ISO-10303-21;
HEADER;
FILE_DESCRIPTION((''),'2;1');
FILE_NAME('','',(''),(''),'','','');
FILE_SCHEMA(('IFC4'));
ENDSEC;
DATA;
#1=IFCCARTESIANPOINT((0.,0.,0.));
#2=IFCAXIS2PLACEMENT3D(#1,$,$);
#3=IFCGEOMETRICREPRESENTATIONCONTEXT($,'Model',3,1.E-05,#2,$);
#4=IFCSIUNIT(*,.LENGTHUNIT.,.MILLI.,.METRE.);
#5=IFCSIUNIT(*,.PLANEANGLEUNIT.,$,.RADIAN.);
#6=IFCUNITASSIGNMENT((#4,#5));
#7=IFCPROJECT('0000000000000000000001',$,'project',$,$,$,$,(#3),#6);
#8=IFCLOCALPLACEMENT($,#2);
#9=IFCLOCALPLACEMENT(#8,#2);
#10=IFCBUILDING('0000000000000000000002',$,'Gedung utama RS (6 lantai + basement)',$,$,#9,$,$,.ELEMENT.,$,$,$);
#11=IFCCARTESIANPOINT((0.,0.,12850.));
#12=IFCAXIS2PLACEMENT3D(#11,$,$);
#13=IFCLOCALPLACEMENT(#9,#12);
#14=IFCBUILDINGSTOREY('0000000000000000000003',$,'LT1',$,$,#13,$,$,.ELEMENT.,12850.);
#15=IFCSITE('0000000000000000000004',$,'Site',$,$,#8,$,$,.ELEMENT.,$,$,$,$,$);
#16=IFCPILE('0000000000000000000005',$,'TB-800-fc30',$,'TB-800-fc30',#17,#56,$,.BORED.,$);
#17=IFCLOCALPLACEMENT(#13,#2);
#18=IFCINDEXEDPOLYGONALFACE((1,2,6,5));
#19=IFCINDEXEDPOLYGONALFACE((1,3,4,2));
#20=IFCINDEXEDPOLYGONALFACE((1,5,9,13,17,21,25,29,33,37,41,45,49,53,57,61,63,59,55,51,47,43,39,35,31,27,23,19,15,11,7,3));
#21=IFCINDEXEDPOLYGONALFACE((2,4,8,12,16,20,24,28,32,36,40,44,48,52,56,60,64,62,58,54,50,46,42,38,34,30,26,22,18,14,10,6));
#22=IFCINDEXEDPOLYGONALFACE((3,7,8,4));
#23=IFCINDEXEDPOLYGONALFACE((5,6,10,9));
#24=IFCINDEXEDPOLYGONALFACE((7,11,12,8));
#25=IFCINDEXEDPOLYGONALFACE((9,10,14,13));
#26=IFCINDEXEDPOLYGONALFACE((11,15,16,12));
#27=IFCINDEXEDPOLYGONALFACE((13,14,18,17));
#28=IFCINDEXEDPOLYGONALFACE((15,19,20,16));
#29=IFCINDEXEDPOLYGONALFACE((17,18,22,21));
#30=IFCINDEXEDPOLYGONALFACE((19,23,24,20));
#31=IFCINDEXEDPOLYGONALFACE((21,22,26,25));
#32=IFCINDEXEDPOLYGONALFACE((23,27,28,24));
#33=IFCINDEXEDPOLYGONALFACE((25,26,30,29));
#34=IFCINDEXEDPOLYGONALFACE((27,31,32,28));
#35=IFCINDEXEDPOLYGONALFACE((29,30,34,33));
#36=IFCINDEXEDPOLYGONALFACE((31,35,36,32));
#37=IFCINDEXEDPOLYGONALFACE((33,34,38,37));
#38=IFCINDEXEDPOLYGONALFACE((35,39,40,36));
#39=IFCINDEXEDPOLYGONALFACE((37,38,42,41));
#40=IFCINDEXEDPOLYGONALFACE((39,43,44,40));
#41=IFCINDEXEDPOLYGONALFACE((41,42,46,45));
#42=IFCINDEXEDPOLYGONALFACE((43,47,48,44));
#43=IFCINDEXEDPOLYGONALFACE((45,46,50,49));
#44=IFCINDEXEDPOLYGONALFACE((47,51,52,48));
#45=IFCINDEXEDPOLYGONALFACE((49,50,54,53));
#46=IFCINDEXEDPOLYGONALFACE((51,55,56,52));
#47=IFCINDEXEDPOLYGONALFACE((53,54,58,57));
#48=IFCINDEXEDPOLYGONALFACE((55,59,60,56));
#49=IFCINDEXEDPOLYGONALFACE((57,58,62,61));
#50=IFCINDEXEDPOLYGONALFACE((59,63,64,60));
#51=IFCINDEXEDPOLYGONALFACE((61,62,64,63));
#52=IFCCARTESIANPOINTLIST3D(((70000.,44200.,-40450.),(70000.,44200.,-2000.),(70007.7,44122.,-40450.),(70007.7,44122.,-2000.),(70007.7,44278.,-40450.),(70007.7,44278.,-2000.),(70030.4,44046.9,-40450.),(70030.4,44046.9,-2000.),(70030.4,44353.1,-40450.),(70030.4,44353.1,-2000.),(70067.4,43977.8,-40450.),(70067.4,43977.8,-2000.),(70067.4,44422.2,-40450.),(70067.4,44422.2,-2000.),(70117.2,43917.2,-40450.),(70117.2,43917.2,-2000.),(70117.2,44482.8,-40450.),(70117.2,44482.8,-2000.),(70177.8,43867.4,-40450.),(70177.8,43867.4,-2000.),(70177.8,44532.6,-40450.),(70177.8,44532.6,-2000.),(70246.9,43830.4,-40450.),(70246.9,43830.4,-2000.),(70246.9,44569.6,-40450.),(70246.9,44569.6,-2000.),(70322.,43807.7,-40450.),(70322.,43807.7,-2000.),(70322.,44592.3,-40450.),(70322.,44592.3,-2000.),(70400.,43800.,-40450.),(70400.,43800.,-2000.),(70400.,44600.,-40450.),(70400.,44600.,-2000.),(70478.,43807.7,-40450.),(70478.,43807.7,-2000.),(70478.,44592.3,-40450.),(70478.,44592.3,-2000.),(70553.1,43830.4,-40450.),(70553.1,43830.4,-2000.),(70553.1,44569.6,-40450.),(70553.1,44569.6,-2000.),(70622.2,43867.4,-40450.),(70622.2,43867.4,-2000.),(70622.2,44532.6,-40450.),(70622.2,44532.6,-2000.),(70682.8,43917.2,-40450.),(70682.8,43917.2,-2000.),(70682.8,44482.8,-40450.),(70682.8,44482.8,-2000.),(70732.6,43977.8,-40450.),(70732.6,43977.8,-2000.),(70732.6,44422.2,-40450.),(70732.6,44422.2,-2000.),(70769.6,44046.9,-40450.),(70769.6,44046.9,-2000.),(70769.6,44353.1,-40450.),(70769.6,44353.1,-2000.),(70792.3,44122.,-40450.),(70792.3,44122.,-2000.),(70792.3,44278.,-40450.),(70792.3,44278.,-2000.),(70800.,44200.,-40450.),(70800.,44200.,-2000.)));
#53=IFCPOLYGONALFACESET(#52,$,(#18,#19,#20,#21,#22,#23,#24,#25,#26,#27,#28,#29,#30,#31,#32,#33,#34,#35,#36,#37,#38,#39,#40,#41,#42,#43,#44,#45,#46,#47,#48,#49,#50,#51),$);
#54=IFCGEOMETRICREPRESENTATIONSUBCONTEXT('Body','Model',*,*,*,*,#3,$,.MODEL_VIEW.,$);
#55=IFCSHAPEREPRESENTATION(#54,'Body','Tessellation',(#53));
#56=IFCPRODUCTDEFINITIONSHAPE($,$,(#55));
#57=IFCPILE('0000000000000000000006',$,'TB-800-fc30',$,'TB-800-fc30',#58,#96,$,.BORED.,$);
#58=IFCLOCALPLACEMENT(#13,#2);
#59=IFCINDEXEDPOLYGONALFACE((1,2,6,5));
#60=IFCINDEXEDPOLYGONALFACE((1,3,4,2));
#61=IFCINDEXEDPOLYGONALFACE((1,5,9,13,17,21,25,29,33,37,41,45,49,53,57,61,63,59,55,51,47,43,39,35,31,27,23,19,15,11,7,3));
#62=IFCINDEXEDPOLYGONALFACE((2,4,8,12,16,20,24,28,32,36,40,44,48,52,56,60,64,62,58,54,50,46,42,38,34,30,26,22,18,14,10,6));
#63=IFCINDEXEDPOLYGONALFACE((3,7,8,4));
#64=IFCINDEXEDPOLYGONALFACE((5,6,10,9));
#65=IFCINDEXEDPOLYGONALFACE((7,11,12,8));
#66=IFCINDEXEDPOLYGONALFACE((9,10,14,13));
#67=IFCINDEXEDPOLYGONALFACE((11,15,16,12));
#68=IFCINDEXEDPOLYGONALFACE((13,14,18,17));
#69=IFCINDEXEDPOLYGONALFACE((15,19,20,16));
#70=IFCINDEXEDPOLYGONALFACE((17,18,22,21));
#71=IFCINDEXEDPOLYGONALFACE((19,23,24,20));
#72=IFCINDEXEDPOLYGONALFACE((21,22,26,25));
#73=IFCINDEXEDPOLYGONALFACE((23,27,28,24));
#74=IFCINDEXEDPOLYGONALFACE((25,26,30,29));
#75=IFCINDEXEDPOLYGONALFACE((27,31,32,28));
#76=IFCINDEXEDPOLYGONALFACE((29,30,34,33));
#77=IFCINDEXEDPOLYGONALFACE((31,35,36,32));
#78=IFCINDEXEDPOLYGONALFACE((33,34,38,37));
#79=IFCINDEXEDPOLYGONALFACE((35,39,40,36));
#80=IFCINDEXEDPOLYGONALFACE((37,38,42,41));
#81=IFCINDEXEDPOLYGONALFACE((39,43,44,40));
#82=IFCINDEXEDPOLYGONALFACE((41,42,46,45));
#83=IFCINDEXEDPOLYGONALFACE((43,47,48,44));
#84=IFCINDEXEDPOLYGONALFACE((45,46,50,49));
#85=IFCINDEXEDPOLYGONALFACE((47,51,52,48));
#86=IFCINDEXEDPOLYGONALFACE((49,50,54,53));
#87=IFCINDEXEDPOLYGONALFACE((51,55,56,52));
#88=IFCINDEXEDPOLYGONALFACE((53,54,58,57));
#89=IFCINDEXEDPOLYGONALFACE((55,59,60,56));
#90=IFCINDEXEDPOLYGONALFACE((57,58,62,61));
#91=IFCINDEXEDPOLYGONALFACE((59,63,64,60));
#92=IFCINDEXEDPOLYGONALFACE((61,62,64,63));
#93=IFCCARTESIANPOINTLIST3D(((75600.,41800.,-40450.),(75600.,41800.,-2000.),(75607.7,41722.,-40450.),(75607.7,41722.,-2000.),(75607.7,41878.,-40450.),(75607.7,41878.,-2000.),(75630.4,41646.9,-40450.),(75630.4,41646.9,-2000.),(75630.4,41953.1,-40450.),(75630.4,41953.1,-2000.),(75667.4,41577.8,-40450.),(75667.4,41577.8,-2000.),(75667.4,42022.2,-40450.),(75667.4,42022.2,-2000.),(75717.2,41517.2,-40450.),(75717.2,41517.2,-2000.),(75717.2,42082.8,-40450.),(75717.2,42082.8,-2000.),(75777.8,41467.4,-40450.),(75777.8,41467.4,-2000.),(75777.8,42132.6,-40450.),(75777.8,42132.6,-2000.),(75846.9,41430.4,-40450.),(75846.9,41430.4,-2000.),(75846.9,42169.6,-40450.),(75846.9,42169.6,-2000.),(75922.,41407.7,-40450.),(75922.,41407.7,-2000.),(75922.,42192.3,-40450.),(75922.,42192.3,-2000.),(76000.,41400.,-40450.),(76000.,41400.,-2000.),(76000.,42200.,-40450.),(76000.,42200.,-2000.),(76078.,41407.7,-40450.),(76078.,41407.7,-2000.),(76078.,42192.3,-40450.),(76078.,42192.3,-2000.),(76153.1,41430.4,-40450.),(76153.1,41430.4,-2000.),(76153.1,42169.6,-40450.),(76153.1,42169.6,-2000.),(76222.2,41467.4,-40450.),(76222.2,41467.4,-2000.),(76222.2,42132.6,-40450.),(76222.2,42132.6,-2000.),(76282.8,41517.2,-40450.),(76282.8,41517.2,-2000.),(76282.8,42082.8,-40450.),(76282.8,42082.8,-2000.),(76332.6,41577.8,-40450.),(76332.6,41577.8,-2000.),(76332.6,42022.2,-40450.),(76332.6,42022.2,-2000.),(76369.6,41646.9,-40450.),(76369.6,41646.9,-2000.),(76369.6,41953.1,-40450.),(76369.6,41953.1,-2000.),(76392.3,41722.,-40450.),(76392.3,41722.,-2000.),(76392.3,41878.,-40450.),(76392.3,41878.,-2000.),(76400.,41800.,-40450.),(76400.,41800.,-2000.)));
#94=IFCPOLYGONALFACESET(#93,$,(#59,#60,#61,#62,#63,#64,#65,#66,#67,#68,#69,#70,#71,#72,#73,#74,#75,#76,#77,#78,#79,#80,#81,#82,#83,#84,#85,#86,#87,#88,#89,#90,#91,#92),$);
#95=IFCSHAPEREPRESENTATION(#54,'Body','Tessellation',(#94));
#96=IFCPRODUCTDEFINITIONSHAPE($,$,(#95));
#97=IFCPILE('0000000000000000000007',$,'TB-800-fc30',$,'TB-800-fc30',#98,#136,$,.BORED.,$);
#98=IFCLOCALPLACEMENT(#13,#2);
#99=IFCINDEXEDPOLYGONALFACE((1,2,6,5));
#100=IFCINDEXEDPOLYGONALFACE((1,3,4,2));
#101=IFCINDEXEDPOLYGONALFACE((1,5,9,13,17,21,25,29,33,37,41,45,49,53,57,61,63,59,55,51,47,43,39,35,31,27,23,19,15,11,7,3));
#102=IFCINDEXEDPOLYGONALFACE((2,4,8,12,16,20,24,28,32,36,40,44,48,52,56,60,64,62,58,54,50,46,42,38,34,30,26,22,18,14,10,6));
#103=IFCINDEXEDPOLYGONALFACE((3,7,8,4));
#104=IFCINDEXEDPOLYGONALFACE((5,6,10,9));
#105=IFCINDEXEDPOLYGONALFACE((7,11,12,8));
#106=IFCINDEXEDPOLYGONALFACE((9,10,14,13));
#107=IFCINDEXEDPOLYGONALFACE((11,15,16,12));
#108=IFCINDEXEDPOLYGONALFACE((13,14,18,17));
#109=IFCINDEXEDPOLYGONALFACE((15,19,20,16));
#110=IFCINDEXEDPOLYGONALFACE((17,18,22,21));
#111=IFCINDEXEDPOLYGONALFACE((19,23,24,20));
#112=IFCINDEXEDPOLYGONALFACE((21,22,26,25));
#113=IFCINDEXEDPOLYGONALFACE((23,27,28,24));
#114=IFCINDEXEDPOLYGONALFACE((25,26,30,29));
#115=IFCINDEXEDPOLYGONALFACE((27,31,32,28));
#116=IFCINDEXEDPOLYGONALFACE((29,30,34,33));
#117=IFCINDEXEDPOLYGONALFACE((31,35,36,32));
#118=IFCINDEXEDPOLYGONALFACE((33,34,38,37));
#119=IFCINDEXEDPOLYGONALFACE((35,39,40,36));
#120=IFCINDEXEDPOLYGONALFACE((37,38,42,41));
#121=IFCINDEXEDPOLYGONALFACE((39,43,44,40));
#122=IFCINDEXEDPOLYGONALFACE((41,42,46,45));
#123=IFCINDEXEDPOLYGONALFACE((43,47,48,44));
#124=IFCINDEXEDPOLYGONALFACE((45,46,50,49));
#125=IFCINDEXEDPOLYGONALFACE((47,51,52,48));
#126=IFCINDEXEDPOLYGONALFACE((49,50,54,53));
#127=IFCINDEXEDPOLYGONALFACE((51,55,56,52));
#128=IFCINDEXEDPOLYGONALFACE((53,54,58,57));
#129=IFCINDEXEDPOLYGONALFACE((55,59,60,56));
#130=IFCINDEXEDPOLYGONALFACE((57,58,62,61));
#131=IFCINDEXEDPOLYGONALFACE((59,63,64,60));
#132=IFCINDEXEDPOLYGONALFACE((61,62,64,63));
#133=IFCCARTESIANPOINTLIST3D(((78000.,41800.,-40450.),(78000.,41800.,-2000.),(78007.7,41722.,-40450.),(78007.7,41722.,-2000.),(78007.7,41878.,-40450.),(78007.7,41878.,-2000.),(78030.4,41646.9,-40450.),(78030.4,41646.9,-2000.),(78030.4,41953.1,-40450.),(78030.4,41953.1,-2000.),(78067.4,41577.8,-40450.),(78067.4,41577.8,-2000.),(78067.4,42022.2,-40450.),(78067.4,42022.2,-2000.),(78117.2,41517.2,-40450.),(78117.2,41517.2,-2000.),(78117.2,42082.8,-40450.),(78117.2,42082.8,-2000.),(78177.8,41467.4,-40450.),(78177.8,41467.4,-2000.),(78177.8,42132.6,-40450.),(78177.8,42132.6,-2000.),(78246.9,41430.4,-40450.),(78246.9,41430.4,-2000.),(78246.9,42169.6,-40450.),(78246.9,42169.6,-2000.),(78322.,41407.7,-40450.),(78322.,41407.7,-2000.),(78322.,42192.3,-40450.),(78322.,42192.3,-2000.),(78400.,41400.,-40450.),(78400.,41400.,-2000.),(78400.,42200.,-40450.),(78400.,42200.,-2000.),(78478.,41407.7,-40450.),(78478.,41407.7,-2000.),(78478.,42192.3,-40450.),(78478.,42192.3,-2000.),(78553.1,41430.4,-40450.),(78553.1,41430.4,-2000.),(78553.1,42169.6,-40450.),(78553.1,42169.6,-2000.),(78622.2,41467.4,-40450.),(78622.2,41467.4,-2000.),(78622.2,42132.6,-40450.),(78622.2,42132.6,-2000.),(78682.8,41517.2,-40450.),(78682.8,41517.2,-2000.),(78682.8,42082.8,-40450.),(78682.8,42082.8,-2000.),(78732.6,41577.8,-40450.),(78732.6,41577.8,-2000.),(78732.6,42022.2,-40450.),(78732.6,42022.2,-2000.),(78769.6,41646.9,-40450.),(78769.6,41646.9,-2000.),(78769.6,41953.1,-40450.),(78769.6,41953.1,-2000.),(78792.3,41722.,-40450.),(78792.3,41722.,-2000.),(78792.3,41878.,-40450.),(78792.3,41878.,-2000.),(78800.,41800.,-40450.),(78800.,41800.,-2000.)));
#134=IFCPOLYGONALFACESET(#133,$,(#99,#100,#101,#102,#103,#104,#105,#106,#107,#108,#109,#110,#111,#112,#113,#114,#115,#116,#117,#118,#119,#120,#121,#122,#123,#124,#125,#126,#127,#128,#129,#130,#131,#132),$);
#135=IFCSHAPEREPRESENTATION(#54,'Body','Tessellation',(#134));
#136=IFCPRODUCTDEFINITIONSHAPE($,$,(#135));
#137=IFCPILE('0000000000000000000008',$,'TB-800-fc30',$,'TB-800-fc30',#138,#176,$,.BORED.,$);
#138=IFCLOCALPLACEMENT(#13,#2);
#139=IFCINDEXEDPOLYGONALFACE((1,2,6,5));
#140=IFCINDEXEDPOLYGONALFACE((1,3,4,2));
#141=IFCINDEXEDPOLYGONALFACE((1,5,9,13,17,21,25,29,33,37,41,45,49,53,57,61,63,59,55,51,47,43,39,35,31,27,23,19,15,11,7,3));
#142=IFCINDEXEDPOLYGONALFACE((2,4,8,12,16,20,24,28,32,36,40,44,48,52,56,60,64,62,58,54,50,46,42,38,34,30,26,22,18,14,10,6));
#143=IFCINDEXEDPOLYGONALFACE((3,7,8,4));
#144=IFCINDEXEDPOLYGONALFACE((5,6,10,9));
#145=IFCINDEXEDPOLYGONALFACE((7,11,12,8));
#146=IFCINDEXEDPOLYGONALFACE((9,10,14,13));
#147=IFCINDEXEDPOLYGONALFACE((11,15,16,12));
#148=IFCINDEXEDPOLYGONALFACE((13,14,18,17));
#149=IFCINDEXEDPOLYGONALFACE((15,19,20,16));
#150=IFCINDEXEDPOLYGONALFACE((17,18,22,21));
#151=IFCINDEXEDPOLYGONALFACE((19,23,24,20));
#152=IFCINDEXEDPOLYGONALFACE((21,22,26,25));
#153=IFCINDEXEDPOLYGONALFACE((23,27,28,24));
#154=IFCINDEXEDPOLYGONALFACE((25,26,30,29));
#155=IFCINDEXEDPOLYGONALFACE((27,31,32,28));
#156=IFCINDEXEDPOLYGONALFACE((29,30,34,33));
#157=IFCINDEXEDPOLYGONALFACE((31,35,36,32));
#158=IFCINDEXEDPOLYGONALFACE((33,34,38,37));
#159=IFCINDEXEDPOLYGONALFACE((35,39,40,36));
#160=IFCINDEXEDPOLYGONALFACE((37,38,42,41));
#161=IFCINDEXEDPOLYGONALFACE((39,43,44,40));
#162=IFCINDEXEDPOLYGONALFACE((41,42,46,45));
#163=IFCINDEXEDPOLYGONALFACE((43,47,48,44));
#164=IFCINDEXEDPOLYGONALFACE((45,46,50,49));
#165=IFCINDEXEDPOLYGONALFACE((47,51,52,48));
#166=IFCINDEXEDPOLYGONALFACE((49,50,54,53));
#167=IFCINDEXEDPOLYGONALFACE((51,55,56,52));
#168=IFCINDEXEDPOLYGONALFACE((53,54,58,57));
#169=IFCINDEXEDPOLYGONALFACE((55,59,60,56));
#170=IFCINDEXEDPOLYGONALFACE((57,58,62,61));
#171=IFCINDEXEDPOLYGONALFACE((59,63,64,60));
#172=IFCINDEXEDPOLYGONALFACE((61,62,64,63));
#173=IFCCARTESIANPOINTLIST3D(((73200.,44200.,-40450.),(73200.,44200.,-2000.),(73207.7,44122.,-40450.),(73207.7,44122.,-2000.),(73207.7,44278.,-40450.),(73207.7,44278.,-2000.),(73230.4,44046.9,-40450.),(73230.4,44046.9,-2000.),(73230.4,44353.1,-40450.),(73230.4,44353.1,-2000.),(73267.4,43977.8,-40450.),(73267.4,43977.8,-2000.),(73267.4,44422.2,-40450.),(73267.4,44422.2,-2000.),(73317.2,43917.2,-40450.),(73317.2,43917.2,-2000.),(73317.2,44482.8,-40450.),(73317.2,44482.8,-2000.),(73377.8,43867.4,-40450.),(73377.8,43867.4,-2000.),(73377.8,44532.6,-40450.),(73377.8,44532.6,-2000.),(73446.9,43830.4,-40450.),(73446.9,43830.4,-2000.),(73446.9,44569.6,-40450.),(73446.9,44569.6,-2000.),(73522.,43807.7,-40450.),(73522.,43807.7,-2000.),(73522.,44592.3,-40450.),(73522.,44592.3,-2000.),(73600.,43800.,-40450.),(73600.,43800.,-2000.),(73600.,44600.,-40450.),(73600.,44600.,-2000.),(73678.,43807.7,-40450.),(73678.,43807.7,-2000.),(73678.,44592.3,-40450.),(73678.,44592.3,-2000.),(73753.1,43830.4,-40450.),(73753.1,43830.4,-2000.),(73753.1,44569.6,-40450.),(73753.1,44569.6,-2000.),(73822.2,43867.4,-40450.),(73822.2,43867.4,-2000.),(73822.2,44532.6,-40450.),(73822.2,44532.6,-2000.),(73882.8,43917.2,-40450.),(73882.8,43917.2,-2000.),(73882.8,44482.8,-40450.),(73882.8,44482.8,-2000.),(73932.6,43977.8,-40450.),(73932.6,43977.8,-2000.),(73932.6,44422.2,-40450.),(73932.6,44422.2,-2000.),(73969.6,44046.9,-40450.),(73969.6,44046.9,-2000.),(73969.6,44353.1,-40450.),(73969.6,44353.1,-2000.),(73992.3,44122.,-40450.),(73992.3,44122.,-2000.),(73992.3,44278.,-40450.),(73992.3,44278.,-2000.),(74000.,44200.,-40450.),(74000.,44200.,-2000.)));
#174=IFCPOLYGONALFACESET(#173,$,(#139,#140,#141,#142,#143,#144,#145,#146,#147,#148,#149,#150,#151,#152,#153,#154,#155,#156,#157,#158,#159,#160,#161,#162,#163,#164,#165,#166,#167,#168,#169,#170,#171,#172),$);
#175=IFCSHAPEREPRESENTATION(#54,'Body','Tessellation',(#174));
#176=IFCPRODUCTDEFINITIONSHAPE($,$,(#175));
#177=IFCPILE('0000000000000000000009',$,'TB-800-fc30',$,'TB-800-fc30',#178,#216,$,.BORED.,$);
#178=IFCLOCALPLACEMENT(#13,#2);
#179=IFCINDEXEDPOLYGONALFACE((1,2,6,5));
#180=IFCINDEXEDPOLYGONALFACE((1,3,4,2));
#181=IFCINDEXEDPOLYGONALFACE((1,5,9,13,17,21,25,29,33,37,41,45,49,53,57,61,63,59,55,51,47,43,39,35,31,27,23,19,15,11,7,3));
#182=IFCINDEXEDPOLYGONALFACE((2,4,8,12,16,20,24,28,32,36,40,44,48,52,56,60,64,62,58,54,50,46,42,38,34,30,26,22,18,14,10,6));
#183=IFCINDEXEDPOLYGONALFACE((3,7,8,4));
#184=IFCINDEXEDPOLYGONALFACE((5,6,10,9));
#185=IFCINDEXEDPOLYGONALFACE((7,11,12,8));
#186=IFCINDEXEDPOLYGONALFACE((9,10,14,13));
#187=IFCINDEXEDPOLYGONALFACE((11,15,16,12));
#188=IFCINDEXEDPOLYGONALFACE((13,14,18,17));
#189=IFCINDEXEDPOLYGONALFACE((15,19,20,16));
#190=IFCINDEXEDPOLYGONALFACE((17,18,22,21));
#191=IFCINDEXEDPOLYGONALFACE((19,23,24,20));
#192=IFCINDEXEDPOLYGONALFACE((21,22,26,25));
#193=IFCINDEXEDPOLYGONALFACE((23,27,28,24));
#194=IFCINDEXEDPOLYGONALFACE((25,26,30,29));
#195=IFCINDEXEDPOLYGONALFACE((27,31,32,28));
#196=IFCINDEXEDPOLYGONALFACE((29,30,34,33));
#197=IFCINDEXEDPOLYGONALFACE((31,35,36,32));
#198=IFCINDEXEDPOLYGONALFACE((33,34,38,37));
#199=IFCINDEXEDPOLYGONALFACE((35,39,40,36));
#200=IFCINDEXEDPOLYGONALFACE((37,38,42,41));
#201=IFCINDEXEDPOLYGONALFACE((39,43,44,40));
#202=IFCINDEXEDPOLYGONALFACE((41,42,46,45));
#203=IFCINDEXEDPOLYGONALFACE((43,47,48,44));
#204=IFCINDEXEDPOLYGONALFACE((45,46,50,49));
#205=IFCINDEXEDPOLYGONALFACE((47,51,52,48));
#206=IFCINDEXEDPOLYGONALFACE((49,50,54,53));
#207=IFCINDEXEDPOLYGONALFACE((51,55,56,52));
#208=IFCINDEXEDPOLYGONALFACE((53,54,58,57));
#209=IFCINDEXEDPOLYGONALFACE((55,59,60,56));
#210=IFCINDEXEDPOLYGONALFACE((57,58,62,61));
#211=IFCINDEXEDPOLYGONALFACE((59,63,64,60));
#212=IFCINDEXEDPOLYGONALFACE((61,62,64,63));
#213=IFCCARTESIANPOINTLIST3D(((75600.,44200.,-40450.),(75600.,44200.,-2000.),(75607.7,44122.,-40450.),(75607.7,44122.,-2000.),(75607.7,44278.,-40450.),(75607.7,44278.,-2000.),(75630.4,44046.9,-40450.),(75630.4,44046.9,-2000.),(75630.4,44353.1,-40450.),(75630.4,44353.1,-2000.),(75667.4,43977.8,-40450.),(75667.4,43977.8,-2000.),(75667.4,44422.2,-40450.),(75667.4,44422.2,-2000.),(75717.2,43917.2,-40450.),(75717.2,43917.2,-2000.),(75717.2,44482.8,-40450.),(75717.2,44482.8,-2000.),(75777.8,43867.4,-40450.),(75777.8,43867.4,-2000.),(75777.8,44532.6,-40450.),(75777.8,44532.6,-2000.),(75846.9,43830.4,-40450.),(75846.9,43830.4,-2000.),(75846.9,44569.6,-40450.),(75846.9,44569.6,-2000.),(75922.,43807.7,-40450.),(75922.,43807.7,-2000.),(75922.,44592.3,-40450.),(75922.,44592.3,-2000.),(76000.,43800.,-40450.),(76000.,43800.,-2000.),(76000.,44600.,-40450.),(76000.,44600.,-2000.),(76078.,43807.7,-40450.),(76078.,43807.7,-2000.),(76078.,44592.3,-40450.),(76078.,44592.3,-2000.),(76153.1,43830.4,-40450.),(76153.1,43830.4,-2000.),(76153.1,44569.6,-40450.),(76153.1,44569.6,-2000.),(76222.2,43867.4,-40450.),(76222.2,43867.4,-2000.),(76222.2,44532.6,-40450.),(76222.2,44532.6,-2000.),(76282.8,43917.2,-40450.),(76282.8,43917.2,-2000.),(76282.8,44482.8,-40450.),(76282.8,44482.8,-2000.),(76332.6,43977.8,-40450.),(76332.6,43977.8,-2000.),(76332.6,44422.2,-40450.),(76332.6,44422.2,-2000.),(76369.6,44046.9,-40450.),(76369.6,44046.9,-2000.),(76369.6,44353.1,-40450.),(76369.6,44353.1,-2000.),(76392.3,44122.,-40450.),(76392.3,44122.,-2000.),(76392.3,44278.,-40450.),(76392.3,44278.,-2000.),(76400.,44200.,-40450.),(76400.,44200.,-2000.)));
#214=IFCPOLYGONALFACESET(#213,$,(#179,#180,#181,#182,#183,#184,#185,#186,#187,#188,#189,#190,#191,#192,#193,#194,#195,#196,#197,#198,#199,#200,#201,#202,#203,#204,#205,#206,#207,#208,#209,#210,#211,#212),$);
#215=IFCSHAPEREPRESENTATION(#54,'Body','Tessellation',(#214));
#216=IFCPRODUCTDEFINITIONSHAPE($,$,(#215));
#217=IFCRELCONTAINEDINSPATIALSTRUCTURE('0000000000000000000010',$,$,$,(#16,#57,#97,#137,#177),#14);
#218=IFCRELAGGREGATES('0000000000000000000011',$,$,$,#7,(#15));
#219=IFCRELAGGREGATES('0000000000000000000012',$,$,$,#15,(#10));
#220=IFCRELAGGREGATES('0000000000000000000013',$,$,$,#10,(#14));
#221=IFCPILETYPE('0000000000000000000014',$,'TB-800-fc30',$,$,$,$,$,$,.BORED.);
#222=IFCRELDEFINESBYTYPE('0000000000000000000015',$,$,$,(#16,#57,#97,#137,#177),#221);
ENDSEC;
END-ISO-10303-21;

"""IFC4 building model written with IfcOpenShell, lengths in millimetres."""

from ifc_helpers import new_model, si_unit, frame, origin, origin_2d, place, context, subcontext, project, spatial, circle, extrude, material_profile, profile_set, profile_usage, type_object, element, save


model = new_model("IFC4")

# Units and contexts
model_context = context("Model", 3, precision=1e-05, world=origin())
body_context = subcontext(model_context, "Body", "Model", "MODEL_VIEW")
ifc_project = project(units=[si_unit("LENGTHUNIT", "METRE", prefix="MILLI"), si_unit("PLANEANGLEUNIT", "RADIAN")], contexts=[model_context])

# Site, building, storey
site_placement = place(None, origin())
site = spatial("IfcSite", under=ifc_project, at=site_placement, Name="Site", CompositionType="ELEMENT")
building_placement = place(site_placement, origin())
building = spatial("IfcBuilding", under=site, at=building_placement, Name="Gedung utama RS (6 lantai + basement)", CompositionType="ELEMENT")
storey_placement = place(building_placement, frame((0.0, 0.0, 12850.0)))
storey = spatial("IfcBuildingStorey", under=building, at=storey_placement, Name="LT1", CompositionType="ELEMENT", Elevation=12850.0)

# Piles
ifc_material_profile_1 = material_profile(None, circle(Radius=400.0, at=origin_2d()), Name="TB-800-fc30")
ifc_profile_set_1 = profile_set([ifc_material_profile_1], Name="TB-800-fc30")
ifc_profile_usage_1 = profile_usage(ifc_profile_set_1, cardinal=5)
pile_type = type_object("IfcPileType", Name="TB-800-fc30", PredefinedType="BORED", material=ifc_profile_set_1)
for number, where, z_axis, x_axis, name in (
    (1, (70400.0, 44200.0, -40450.0), (0.0, 0.0, 1.0), (1.0, 0.0, 0.0), "TB-800-fc30"),
    (2, (76000.0, 41800.0, -40450.0), (0.0, 0.0, 1.0), (1.0, 0.0, 0.0), "TB-800-fc30"),
    (3, (78400.0, 41800.0, -40450.0), (0.0, 0.0, 1.0), (1.0, 0.0, 0.0), "TB-800-fc30"),
    (4, (73600.0, 44200.0, -40450.0), (0.0, 0.0, 1.0), (1.0, 0.0, 0.0), "TB-800-fc30"),
    (5, (76000.0, 44200.0, -40450.0), (0.0, 0.0, 1.0), (1.0, 0.0, 0.0), "TB-800-fc30"),
):
    element("IfcPile", number, at=place(storey_placement, frame(where, z_axis=z_axis, x_axis=x_axis)), inside=storey, type_object=pile_type, material=ifc_profile_usage_1, Name=name, ObjectType="TB-800-fc30", PredefinedType="BORED", context=body_context, shape_type="SweptSolid", body=[
        extrude(circle(Radius=400.0, at=origin_2d()), origin(), (0.0, 0.0, 1.0), 38450.0),
    ])

save(model, "model.ifc")
